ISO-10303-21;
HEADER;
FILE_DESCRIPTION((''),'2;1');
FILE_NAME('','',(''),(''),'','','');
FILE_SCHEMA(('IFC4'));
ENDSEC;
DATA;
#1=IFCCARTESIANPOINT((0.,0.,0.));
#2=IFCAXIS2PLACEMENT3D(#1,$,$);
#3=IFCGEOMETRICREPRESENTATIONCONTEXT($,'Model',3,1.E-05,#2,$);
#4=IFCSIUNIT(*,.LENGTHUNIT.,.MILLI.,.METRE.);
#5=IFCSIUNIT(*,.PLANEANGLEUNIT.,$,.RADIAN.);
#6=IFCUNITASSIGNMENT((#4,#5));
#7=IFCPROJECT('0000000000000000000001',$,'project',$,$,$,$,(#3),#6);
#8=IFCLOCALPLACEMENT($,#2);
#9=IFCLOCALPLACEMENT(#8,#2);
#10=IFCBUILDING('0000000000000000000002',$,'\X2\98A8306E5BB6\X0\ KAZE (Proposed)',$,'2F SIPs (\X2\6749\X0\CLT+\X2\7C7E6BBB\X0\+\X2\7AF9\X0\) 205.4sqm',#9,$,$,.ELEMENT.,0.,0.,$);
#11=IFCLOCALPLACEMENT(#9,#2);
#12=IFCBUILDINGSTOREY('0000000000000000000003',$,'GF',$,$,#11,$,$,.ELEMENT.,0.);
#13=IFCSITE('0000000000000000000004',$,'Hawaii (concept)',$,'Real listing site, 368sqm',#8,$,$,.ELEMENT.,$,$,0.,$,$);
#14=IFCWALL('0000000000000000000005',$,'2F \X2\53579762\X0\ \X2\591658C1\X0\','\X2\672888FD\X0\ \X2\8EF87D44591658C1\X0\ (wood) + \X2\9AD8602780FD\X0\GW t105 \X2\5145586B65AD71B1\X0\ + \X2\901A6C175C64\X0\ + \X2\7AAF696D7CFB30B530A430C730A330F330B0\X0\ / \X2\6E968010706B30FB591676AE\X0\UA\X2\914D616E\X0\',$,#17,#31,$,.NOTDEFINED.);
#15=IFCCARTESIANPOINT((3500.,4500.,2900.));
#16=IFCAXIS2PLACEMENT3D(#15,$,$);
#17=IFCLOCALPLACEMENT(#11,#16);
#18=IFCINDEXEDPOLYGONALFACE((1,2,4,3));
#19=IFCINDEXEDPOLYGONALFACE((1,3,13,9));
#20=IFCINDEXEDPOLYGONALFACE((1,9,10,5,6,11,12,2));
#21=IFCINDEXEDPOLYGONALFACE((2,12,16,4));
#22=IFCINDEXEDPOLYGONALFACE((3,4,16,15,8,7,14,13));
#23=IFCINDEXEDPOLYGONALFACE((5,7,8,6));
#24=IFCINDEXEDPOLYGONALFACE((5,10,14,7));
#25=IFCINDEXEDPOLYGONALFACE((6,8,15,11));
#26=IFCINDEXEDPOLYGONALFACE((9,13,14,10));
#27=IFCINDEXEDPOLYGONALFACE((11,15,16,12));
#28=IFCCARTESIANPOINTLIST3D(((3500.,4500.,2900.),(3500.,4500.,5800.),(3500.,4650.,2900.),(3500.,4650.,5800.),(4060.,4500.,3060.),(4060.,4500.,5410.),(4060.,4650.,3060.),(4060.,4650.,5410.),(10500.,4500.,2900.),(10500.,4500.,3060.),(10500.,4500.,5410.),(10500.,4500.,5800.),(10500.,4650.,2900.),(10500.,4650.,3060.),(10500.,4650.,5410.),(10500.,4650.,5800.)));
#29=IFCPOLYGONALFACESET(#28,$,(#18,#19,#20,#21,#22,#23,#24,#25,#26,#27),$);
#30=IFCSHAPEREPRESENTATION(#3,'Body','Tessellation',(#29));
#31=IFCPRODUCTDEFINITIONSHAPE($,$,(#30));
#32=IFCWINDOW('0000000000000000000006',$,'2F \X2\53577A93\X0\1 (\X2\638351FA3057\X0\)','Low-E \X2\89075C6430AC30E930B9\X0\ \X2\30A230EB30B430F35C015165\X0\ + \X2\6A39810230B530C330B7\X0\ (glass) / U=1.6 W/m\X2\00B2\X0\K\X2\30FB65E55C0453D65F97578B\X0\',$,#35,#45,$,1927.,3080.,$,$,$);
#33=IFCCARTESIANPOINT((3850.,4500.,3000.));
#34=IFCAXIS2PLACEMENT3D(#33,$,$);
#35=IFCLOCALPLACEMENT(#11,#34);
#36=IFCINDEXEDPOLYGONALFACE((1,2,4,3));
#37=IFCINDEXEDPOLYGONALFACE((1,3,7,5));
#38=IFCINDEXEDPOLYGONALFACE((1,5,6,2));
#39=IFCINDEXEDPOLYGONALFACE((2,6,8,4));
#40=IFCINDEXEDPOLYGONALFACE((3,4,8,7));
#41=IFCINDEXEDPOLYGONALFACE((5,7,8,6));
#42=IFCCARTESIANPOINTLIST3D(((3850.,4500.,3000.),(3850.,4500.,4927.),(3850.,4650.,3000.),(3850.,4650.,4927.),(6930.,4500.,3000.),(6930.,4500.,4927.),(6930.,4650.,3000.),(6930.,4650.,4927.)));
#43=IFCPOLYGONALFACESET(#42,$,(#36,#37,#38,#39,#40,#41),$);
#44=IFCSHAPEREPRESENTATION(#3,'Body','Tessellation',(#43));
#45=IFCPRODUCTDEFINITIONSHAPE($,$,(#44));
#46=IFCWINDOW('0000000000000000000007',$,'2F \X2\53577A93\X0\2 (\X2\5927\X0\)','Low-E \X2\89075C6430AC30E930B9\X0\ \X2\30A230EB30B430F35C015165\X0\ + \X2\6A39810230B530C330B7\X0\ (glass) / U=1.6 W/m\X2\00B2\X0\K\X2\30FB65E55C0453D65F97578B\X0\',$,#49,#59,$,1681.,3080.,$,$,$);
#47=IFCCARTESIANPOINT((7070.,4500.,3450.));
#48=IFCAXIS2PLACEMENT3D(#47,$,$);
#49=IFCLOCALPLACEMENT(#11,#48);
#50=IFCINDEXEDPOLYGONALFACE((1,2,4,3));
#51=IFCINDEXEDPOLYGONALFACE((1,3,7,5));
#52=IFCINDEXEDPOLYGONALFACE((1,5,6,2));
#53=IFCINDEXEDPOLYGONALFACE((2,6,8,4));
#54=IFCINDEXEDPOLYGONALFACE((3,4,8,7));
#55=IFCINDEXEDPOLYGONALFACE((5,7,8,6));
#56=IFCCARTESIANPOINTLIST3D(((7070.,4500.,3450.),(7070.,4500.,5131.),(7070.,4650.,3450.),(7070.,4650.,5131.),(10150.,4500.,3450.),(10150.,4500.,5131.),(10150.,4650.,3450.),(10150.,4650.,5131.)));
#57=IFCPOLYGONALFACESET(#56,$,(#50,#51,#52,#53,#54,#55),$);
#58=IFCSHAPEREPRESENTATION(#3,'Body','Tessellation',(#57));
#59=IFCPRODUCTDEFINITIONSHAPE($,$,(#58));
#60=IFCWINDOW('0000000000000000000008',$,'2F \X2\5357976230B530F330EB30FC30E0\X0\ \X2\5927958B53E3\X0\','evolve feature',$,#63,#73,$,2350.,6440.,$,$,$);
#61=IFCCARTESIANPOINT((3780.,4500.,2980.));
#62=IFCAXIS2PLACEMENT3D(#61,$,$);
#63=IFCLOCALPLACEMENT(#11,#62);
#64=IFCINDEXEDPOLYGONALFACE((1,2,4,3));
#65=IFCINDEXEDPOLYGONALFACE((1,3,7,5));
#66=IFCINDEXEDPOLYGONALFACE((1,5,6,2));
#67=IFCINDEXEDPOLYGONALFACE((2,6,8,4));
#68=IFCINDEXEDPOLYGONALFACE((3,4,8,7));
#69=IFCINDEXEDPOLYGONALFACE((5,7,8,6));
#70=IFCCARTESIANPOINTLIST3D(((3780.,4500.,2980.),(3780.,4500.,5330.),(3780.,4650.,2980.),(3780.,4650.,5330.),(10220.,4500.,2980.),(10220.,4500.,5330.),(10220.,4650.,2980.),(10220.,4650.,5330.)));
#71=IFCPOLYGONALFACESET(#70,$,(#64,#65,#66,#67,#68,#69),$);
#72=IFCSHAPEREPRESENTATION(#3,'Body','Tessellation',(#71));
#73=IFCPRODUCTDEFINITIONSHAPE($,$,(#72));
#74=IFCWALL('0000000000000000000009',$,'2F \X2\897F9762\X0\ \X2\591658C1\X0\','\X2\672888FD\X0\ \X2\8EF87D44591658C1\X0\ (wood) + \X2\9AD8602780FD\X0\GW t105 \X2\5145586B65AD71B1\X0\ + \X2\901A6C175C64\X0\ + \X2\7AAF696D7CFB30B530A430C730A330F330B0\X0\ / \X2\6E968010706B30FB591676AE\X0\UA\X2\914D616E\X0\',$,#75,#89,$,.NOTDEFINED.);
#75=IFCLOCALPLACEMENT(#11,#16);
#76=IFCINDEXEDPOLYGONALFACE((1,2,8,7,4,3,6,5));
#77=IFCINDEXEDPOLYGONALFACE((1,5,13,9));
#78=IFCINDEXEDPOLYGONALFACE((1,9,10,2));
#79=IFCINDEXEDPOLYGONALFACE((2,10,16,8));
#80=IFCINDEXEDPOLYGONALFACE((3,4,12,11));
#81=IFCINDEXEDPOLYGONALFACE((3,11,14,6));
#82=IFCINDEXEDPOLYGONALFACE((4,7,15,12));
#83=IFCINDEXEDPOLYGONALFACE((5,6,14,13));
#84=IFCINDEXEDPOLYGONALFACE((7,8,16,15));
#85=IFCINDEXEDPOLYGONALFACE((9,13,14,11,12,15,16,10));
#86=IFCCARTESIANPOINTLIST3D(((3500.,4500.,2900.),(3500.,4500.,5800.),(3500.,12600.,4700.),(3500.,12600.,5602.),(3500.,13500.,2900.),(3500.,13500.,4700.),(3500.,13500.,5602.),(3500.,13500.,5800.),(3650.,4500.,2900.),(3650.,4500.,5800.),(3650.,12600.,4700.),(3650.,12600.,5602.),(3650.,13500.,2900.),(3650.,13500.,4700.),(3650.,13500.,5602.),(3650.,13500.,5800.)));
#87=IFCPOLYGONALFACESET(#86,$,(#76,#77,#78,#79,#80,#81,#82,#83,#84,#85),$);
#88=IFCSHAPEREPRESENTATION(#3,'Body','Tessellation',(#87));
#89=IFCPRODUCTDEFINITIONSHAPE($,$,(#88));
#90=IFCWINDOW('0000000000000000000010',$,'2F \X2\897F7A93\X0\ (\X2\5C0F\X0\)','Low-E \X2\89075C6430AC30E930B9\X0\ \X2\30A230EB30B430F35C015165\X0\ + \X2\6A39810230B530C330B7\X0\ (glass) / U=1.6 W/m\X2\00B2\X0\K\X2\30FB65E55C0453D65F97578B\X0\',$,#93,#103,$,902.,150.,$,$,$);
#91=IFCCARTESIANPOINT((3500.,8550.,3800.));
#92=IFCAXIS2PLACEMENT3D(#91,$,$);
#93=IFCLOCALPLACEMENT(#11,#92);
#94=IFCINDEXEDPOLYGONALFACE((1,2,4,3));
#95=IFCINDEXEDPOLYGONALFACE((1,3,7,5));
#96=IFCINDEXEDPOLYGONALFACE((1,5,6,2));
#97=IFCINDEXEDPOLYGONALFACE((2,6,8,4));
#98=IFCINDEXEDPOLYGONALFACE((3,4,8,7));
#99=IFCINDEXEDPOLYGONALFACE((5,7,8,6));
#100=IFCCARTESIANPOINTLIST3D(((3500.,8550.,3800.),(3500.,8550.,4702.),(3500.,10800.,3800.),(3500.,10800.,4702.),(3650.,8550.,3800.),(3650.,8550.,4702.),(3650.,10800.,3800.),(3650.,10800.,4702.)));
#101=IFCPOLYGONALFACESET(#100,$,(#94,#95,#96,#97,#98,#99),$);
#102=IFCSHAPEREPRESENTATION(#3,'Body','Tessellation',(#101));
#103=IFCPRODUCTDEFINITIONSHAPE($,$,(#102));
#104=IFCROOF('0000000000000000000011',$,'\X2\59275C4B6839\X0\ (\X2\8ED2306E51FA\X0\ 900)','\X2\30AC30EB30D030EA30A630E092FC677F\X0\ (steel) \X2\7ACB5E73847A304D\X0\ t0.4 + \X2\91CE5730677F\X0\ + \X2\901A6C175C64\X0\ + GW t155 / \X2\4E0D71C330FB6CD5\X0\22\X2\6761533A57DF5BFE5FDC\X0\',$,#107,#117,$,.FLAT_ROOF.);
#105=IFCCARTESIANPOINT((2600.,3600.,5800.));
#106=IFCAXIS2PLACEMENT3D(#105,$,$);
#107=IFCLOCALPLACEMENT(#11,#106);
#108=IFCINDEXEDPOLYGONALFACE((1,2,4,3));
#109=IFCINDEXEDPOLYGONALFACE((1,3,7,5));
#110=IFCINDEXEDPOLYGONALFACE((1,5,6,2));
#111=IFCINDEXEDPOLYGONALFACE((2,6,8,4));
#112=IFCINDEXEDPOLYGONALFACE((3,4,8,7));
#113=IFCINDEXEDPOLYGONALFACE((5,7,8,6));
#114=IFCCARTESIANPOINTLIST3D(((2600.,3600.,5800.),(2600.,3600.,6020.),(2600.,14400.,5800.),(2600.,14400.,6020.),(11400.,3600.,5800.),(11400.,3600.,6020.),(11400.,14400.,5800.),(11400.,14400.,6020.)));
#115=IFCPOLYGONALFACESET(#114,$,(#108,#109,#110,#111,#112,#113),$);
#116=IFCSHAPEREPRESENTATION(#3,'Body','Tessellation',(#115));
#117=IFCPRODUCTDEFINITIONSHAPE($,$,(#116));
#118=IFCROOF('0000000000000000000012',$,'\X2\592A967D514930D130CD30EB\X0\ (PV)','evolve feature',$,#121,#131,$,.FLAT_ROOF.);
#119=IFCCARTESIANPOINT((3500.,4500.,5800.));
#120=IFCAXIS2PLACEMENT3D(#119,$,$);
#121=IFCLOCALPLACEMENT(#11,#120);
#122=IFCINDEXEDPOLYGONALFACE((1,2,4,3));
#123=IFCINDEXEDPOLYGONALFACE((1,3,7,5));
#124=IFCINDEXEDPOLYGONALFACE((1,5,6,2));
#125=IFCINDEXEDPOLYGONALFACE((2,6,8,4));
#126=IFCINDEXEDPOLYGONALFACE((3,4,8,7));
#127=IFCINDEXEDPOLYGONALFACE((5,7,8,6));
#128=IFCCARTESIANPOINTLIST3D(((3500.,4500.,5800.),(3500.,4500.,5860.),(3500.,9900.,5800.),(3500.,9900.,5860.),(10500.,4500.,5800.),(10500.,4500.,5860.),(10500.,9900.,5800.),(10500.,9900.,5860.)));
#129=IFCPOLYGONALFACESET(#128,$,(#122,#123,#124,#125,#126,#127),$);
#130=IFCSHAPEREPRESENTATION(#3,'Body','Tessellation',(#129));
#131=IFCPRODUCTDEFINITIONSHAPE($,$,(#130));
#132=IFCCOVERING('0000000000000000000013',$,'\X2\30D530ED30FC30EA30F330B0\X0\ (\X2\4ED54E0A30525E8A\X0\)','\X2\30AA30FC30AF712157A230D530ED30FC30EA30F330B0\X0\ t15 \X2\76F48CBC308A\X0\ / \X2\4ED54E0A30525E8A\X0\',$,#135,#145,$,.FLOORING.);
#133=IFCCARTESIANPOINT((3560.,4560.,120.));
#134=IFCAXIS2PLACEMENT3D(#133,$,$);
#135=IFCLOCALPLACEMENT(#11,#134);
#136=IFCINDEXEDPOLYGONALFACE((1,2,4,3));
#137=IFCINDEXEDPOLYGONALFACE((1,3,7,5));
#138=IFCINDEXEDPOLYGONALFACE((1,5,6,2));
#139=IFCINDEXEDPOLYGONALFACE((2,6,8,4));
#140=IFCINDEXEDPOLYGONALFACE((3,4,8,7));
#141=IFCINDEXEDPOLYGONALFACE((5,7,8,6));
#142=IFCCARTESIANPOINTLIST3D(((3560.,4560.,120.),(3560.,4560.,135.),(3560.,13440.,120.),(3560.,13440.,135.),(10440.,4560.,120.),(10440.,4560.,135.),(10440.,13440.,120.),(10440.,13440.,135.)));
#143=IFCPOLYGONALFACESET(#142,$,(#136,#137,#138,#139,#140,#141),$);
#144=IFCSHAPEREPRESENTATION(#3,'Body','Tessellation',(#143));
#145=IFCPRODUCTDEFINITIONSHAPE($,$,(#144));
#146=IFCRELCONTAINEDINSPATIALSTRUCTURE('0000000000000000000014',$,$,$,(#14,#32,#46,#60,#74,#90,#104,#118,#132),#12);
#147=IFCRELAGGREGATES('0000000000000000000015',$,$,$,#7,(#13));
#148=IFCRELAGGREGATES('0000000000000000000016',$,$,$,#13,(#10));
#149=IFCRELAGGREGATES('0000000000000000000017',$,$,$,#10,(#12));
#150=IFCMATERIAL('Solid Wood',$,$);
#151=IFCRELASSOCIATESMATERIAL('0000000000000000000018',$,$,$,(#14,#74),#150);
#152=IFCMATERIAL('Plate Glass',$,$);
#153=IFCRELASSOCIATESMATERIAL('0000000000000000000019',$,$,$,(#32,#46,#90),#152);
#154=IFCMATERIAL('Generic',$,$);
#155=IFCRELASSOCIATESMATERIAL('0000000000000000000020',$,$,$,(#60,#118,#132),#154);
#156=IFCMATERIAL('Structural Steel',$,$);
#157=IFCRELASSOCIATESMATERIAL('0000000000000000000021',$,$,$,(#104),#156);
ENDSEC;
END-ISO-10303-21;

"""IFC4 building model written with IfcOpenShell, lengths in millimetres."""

from ifc_helpers import new_model, si_unit, frame, frame_2d, origin, place, context, project, spatial, rectangle, extrude, material, element, fill, save


model = new_model("IFC4")

# Units and contexts
model_context = context("Model", 3, precision=1e-05, world=origin())
ifc_project = project(units=[si_unit("LENGTHUNIT", "METRE", prefix="MILLI"), si_unit("PLANEANGLEUNIT", "RADIAN")], contexts=[model_context])

# Site, building, storey
site_placement = place(None, origin())
site = spatial("IfcSite", under=ifc_project, at=site_placement, Name="Hawaii (concept)", ObjectType="Real listing site, 368sqm", CompositionType="ELEMENT", RefElevation=0.0)
building_placement = place(site_placement, origin())
building = spatial("IfcBuilding", under=site, at=building_placement, Name="風の家 KAZE (Proposed)", ObjectType="2F SIPs (杉CLT+籾殻+竹) 205.4sqm", CompositionType="ELEMENT", ElevationOfRefHeight=0.0, ElevationOfTerrain=0.0)
storey_placement = place(building_placement, origin())
storey = spatial("IfcBuildingStorey", under=building, at=storey_placement, Name="GF", CompositionType="ELEMENT", Elevation=0.0)

# Shared definitions
ifc_material_1 = material(Name="Solid Wood")
ifc_material_2 = material(Name="Generic")

# Shared definitions
ifc_material_3 = material(Name="Plate Glass")

# Wall, openings, windows
wall_1_placement = place(storey_placement, frame((3500.0, 4500.0, 2900.0)))
wall_1 = element("IfcWall", 1, at=wall_1_placement, inside=storey, material=ifc_material_1, Name="2F 南面 外壁", Description="木製 軸組外壁 (wood) + 高性能GW t105 充填断熱 + 通気層 + 窯業系サイディング / 準耐火・外皮UA配慮", PredefinedType="NOTDEFINED", context=model_context, shape_type="SweptSolid", body=[
    extrude(rectangle(XDim=7000.0, YDim=150.0, at=frame_2d((3500.0, 75.0))), frame((3500.0, 4500.0, 2900.0)), (0.0, 0.0, 1.0), 2900.0),
])
opening_1_placement = place(storey_placement, frame((3850.0, 4500.0, 3000.0)))
opening_1 = element("IfcOpeningElement", 2, at=opening_1_placement, cuts=wall_1, PredefinedType="NOTDEFINED", context=model_context, shape_type="SweptSolid", body=[
    extrude(rectangle(XDim=3080.0, YDim=150.0, at=frame_2d((1540.0, 75.0))), frame((3850.0, 4500.0, 3000.0)), (0.0, 0.0, 1.0), 1927.0),
])
opening_2_placement = place(storey_placement, frame((7070.0, 4500.0, 3450.0)))
opening_2 = element("IfcOpeningElement", 3, at=opening_2_placement, cuts=wall_1, PredefinedType="NOTDEFINED", context=model_context, shape_type="SweptSolid", body=[
    extrude(rectangle(XDim=3080.0, YDim=150.0, at=frame_2d((1540.0, 75.0))), frame((7070.0, 4500.0, 3450.0)), (0.0, 0.0, 1.0), 1681.0),
])
opening_3_placement = place(storey_placement, frame((3780.0, 4500.0, 2980.0)))
opening_3 = element("IfcOpeningElement", 4, at=opening_3_placement, cuts=wall_1, PredefinedType="NOTDEFINED", context=model_context, shape_type="SweptSolid", body=[
    extrude(rectangle(XDim=6440.0, YDim=150.0, at=frame_2d((3220.0, 75.0))), frame((3780.0, 4500.0, 2980.0)), (0.0, 0.0, 1.0), 2350.0),
])
window_1_placement = place(storey_placement, frame((3850.0, 4500.0, 3000.0)))
window_1 = element("IfcWindow", 5, at=window_1_placement, inside=storey, material=ifc_material_3, Name="2F 南窓1 (掃出し)", Description="Low-E 複層ガラス アルゴン封入 + 樹脂サッシ (glass) / U=1.6 W/m²K・日射取得型", OverallHeight=1927.0, OverallWidth=3080.0, context=model_context, shape_type="SweptSolid", body=[
    extrude(rectangle(XDim=3080.0, YDim=150.0, at=frame_2d((1540.0, 75.0))), frame((3850.0, 4500.0, 3000.0)), (0.0, 0.0, 1.0), 1927.0),
])
fill(opening_1, window_1)
window_2_placement = place(storey_placement, frame((7070.0, 4500.0, 3450.0)))
window_2 = element("IfcWindow", 6, at=window_2_placement, inside=storey, material=ifc_material_3, Name="2F 南窓2 (大)", Description="Low-E 複層ガラス アルゴン封入 + 樹脂サッシ (glass) / U=1.6 W/m²K・日射取得型", OverallHeight=1681.0, OverallWidth=3080.0, context=model_context, shape_type="SweptSolid", body=[
    extrude(rectangle(XDim=3080.0, YDim=150.0, at=frame_2d((1540.0, 75.0))), frame((7070.0, 4500.0, 3450.0)), (0.0, 0.0, 1.0), 1681.0),
])
fill(opening_2, window_2)
window_3_placement = place(storey_placement, frame((3780.0, 4500.0, 2980.0)))
window_3 = element("IfcWindow", 7, at=window_3_placement, inside=storey, material=ifc_material_2, Name="2F 南面サンルーム 大開口", Description="evolve feature", OverallHeight=2350.0, OverallWidth=6440.0, context=model_context, shape_type="SweptSolid", body=[
    extrude(rectangle(XDim=6440.0, YDim=150.0, at=frame_2d((3220.0, 75.0))), frame((3780.0, 4500.0, 2980.0)), (0.0, 0.0, 1.0), 2350.0),
])
fill(opening_3, window_3)

# Wall, opening, window
wall_2_placement = place(storey_placement, frame((3500.0, 4500.0, 2900.0)))
wall_2 = element("IfcWall", 8, at=wall_2_placement, inside=storey, material=ifc_material_1, Name="2F 西面 外壁", Description="木製 軸組外壁 (wood) + 高性能GW t105 充填断熱 + 通気層 + 窯業系サイディング / 準耐火・外皮UA配慮", PredefinedType="NOTDEFINED", context=model_context, shape_type="SweptSolid", body=[
    extrude(rectangle(XDim=150.0, YDim=9000.0, at=frame_2d((75.0, 4500.0))), frame((3500.0, 4500.0, 2900.0)), (0.0, 0.0, 1.0), 2900.0),
])
opening_4_placement = place(storey_placement, frame((3500.0, 8550.0, 3800.0)))
opening_4 = element("IfcOpeningElement", 9, at=opening_4_placement, cuts=wall_2, PredefinedType="NOTDEFINED", context=model_context, shape_type="SweptSolid", body=[
    extrude(rectangle(XDim=150.0, YDim=2250.0, at=frame_2d((75.0, 1125.0))), frame((3500.0, 8550.0, 3800.0)), (0.0, 0.0, 1.0), 902.0),
])
window_4_placement = place(storey_placement, frame((3500.0, 8550.0, 3800.0)))
window_4 = element("IfcWindow", 10, at=window_4_placement, inside=storey, material=ifc_material_3, Name="2F 西窓 (小)", Description="Low-E 複層ガラス アルゴン封入 + 樹脂サッシ (glass) / U=1.6 W/m²K・日射取得型", OverallHeight=902.0, OverallWidth=150.0, context=model_context, shape_type="SweptSolid", body=[
    extrude(rectangle(XDim=150.0, YDim=2250.0, at=frame_2d((75.0, 1125.0))), frame((3500.0, 8550.0, 3800.0)), (0.0, 0.0, 1.0), 902.0),
])
fill(opening_4, window_4)

# Roofs
ifc_material_4 = material(Name="Structural Steel")
roof_1_placement = place(storey_placement, frame((2600.0, 3600.0, 5800.0)))
element("IfcRoof", 11, at=roof_1_placement, inside=storey, material=ifc_material_4, Name="大屋根 (軒の出 900)", Description="ガルバリウム鋼板 (steel) 立平葺き t0.4 + 野地板 + 通気層 + GW t155 / 不燃・法22条区域対応", PredefinedType="FLAT_ROOF", context=model_context, shape_type="SweptSolid", body=[
    extrude(rectangle(XDim=8800.0, YDim=10800.0, at=frame_2d((4400.0, 5400.0))), frame((2600.0, 3600.0, 5800.0)), (0.0, 0.0, 1.0), 220.0),
])
roof_2_placement = place(storey_placement, frame((3500.0, 4500.0, 5800.0)))
element("IfcRoof", 12, at=roof_2_placement, inside=storey, material=ifc_material_2, Name="太陽光パネル (PV)", Description="evolve feature", PredefinedType="FLAT_ROOF", context=model_context, shape_type="SweptSolid", body=[
    extrude(rectangle(XDim=7000.0, YDim=5400.0, at=frame_2d((3500.0, 2700.0))), frame((3500.0, 4500.0, 5800.0)), (0.0, 0.0, 1.0), 60.0),
])

# Covering
covering_placement = place(storey_placement, frame((3560.0, 4560.0, 120.0)))
element("IfcCovering", 13, at=covering_placement, inside=storey, material=ifc_material_2, Name="フローリング (仕上げ床)", Description="オーク無垢フローリング t15 直貼り / 仕上げ床", PredefinedType="FLOORING", context=model_context, shape_type="SweptSolid", body=[
    extrude(rectangle(XDim=6880.0, YDim=8880.0, at=frame_2d((3440.0, 4440.0))), frame((3560.0, 4560.0, 120.0)), (0.0, 0.0, 1.0), 15.0),
])

save(model, "model.ifc")
